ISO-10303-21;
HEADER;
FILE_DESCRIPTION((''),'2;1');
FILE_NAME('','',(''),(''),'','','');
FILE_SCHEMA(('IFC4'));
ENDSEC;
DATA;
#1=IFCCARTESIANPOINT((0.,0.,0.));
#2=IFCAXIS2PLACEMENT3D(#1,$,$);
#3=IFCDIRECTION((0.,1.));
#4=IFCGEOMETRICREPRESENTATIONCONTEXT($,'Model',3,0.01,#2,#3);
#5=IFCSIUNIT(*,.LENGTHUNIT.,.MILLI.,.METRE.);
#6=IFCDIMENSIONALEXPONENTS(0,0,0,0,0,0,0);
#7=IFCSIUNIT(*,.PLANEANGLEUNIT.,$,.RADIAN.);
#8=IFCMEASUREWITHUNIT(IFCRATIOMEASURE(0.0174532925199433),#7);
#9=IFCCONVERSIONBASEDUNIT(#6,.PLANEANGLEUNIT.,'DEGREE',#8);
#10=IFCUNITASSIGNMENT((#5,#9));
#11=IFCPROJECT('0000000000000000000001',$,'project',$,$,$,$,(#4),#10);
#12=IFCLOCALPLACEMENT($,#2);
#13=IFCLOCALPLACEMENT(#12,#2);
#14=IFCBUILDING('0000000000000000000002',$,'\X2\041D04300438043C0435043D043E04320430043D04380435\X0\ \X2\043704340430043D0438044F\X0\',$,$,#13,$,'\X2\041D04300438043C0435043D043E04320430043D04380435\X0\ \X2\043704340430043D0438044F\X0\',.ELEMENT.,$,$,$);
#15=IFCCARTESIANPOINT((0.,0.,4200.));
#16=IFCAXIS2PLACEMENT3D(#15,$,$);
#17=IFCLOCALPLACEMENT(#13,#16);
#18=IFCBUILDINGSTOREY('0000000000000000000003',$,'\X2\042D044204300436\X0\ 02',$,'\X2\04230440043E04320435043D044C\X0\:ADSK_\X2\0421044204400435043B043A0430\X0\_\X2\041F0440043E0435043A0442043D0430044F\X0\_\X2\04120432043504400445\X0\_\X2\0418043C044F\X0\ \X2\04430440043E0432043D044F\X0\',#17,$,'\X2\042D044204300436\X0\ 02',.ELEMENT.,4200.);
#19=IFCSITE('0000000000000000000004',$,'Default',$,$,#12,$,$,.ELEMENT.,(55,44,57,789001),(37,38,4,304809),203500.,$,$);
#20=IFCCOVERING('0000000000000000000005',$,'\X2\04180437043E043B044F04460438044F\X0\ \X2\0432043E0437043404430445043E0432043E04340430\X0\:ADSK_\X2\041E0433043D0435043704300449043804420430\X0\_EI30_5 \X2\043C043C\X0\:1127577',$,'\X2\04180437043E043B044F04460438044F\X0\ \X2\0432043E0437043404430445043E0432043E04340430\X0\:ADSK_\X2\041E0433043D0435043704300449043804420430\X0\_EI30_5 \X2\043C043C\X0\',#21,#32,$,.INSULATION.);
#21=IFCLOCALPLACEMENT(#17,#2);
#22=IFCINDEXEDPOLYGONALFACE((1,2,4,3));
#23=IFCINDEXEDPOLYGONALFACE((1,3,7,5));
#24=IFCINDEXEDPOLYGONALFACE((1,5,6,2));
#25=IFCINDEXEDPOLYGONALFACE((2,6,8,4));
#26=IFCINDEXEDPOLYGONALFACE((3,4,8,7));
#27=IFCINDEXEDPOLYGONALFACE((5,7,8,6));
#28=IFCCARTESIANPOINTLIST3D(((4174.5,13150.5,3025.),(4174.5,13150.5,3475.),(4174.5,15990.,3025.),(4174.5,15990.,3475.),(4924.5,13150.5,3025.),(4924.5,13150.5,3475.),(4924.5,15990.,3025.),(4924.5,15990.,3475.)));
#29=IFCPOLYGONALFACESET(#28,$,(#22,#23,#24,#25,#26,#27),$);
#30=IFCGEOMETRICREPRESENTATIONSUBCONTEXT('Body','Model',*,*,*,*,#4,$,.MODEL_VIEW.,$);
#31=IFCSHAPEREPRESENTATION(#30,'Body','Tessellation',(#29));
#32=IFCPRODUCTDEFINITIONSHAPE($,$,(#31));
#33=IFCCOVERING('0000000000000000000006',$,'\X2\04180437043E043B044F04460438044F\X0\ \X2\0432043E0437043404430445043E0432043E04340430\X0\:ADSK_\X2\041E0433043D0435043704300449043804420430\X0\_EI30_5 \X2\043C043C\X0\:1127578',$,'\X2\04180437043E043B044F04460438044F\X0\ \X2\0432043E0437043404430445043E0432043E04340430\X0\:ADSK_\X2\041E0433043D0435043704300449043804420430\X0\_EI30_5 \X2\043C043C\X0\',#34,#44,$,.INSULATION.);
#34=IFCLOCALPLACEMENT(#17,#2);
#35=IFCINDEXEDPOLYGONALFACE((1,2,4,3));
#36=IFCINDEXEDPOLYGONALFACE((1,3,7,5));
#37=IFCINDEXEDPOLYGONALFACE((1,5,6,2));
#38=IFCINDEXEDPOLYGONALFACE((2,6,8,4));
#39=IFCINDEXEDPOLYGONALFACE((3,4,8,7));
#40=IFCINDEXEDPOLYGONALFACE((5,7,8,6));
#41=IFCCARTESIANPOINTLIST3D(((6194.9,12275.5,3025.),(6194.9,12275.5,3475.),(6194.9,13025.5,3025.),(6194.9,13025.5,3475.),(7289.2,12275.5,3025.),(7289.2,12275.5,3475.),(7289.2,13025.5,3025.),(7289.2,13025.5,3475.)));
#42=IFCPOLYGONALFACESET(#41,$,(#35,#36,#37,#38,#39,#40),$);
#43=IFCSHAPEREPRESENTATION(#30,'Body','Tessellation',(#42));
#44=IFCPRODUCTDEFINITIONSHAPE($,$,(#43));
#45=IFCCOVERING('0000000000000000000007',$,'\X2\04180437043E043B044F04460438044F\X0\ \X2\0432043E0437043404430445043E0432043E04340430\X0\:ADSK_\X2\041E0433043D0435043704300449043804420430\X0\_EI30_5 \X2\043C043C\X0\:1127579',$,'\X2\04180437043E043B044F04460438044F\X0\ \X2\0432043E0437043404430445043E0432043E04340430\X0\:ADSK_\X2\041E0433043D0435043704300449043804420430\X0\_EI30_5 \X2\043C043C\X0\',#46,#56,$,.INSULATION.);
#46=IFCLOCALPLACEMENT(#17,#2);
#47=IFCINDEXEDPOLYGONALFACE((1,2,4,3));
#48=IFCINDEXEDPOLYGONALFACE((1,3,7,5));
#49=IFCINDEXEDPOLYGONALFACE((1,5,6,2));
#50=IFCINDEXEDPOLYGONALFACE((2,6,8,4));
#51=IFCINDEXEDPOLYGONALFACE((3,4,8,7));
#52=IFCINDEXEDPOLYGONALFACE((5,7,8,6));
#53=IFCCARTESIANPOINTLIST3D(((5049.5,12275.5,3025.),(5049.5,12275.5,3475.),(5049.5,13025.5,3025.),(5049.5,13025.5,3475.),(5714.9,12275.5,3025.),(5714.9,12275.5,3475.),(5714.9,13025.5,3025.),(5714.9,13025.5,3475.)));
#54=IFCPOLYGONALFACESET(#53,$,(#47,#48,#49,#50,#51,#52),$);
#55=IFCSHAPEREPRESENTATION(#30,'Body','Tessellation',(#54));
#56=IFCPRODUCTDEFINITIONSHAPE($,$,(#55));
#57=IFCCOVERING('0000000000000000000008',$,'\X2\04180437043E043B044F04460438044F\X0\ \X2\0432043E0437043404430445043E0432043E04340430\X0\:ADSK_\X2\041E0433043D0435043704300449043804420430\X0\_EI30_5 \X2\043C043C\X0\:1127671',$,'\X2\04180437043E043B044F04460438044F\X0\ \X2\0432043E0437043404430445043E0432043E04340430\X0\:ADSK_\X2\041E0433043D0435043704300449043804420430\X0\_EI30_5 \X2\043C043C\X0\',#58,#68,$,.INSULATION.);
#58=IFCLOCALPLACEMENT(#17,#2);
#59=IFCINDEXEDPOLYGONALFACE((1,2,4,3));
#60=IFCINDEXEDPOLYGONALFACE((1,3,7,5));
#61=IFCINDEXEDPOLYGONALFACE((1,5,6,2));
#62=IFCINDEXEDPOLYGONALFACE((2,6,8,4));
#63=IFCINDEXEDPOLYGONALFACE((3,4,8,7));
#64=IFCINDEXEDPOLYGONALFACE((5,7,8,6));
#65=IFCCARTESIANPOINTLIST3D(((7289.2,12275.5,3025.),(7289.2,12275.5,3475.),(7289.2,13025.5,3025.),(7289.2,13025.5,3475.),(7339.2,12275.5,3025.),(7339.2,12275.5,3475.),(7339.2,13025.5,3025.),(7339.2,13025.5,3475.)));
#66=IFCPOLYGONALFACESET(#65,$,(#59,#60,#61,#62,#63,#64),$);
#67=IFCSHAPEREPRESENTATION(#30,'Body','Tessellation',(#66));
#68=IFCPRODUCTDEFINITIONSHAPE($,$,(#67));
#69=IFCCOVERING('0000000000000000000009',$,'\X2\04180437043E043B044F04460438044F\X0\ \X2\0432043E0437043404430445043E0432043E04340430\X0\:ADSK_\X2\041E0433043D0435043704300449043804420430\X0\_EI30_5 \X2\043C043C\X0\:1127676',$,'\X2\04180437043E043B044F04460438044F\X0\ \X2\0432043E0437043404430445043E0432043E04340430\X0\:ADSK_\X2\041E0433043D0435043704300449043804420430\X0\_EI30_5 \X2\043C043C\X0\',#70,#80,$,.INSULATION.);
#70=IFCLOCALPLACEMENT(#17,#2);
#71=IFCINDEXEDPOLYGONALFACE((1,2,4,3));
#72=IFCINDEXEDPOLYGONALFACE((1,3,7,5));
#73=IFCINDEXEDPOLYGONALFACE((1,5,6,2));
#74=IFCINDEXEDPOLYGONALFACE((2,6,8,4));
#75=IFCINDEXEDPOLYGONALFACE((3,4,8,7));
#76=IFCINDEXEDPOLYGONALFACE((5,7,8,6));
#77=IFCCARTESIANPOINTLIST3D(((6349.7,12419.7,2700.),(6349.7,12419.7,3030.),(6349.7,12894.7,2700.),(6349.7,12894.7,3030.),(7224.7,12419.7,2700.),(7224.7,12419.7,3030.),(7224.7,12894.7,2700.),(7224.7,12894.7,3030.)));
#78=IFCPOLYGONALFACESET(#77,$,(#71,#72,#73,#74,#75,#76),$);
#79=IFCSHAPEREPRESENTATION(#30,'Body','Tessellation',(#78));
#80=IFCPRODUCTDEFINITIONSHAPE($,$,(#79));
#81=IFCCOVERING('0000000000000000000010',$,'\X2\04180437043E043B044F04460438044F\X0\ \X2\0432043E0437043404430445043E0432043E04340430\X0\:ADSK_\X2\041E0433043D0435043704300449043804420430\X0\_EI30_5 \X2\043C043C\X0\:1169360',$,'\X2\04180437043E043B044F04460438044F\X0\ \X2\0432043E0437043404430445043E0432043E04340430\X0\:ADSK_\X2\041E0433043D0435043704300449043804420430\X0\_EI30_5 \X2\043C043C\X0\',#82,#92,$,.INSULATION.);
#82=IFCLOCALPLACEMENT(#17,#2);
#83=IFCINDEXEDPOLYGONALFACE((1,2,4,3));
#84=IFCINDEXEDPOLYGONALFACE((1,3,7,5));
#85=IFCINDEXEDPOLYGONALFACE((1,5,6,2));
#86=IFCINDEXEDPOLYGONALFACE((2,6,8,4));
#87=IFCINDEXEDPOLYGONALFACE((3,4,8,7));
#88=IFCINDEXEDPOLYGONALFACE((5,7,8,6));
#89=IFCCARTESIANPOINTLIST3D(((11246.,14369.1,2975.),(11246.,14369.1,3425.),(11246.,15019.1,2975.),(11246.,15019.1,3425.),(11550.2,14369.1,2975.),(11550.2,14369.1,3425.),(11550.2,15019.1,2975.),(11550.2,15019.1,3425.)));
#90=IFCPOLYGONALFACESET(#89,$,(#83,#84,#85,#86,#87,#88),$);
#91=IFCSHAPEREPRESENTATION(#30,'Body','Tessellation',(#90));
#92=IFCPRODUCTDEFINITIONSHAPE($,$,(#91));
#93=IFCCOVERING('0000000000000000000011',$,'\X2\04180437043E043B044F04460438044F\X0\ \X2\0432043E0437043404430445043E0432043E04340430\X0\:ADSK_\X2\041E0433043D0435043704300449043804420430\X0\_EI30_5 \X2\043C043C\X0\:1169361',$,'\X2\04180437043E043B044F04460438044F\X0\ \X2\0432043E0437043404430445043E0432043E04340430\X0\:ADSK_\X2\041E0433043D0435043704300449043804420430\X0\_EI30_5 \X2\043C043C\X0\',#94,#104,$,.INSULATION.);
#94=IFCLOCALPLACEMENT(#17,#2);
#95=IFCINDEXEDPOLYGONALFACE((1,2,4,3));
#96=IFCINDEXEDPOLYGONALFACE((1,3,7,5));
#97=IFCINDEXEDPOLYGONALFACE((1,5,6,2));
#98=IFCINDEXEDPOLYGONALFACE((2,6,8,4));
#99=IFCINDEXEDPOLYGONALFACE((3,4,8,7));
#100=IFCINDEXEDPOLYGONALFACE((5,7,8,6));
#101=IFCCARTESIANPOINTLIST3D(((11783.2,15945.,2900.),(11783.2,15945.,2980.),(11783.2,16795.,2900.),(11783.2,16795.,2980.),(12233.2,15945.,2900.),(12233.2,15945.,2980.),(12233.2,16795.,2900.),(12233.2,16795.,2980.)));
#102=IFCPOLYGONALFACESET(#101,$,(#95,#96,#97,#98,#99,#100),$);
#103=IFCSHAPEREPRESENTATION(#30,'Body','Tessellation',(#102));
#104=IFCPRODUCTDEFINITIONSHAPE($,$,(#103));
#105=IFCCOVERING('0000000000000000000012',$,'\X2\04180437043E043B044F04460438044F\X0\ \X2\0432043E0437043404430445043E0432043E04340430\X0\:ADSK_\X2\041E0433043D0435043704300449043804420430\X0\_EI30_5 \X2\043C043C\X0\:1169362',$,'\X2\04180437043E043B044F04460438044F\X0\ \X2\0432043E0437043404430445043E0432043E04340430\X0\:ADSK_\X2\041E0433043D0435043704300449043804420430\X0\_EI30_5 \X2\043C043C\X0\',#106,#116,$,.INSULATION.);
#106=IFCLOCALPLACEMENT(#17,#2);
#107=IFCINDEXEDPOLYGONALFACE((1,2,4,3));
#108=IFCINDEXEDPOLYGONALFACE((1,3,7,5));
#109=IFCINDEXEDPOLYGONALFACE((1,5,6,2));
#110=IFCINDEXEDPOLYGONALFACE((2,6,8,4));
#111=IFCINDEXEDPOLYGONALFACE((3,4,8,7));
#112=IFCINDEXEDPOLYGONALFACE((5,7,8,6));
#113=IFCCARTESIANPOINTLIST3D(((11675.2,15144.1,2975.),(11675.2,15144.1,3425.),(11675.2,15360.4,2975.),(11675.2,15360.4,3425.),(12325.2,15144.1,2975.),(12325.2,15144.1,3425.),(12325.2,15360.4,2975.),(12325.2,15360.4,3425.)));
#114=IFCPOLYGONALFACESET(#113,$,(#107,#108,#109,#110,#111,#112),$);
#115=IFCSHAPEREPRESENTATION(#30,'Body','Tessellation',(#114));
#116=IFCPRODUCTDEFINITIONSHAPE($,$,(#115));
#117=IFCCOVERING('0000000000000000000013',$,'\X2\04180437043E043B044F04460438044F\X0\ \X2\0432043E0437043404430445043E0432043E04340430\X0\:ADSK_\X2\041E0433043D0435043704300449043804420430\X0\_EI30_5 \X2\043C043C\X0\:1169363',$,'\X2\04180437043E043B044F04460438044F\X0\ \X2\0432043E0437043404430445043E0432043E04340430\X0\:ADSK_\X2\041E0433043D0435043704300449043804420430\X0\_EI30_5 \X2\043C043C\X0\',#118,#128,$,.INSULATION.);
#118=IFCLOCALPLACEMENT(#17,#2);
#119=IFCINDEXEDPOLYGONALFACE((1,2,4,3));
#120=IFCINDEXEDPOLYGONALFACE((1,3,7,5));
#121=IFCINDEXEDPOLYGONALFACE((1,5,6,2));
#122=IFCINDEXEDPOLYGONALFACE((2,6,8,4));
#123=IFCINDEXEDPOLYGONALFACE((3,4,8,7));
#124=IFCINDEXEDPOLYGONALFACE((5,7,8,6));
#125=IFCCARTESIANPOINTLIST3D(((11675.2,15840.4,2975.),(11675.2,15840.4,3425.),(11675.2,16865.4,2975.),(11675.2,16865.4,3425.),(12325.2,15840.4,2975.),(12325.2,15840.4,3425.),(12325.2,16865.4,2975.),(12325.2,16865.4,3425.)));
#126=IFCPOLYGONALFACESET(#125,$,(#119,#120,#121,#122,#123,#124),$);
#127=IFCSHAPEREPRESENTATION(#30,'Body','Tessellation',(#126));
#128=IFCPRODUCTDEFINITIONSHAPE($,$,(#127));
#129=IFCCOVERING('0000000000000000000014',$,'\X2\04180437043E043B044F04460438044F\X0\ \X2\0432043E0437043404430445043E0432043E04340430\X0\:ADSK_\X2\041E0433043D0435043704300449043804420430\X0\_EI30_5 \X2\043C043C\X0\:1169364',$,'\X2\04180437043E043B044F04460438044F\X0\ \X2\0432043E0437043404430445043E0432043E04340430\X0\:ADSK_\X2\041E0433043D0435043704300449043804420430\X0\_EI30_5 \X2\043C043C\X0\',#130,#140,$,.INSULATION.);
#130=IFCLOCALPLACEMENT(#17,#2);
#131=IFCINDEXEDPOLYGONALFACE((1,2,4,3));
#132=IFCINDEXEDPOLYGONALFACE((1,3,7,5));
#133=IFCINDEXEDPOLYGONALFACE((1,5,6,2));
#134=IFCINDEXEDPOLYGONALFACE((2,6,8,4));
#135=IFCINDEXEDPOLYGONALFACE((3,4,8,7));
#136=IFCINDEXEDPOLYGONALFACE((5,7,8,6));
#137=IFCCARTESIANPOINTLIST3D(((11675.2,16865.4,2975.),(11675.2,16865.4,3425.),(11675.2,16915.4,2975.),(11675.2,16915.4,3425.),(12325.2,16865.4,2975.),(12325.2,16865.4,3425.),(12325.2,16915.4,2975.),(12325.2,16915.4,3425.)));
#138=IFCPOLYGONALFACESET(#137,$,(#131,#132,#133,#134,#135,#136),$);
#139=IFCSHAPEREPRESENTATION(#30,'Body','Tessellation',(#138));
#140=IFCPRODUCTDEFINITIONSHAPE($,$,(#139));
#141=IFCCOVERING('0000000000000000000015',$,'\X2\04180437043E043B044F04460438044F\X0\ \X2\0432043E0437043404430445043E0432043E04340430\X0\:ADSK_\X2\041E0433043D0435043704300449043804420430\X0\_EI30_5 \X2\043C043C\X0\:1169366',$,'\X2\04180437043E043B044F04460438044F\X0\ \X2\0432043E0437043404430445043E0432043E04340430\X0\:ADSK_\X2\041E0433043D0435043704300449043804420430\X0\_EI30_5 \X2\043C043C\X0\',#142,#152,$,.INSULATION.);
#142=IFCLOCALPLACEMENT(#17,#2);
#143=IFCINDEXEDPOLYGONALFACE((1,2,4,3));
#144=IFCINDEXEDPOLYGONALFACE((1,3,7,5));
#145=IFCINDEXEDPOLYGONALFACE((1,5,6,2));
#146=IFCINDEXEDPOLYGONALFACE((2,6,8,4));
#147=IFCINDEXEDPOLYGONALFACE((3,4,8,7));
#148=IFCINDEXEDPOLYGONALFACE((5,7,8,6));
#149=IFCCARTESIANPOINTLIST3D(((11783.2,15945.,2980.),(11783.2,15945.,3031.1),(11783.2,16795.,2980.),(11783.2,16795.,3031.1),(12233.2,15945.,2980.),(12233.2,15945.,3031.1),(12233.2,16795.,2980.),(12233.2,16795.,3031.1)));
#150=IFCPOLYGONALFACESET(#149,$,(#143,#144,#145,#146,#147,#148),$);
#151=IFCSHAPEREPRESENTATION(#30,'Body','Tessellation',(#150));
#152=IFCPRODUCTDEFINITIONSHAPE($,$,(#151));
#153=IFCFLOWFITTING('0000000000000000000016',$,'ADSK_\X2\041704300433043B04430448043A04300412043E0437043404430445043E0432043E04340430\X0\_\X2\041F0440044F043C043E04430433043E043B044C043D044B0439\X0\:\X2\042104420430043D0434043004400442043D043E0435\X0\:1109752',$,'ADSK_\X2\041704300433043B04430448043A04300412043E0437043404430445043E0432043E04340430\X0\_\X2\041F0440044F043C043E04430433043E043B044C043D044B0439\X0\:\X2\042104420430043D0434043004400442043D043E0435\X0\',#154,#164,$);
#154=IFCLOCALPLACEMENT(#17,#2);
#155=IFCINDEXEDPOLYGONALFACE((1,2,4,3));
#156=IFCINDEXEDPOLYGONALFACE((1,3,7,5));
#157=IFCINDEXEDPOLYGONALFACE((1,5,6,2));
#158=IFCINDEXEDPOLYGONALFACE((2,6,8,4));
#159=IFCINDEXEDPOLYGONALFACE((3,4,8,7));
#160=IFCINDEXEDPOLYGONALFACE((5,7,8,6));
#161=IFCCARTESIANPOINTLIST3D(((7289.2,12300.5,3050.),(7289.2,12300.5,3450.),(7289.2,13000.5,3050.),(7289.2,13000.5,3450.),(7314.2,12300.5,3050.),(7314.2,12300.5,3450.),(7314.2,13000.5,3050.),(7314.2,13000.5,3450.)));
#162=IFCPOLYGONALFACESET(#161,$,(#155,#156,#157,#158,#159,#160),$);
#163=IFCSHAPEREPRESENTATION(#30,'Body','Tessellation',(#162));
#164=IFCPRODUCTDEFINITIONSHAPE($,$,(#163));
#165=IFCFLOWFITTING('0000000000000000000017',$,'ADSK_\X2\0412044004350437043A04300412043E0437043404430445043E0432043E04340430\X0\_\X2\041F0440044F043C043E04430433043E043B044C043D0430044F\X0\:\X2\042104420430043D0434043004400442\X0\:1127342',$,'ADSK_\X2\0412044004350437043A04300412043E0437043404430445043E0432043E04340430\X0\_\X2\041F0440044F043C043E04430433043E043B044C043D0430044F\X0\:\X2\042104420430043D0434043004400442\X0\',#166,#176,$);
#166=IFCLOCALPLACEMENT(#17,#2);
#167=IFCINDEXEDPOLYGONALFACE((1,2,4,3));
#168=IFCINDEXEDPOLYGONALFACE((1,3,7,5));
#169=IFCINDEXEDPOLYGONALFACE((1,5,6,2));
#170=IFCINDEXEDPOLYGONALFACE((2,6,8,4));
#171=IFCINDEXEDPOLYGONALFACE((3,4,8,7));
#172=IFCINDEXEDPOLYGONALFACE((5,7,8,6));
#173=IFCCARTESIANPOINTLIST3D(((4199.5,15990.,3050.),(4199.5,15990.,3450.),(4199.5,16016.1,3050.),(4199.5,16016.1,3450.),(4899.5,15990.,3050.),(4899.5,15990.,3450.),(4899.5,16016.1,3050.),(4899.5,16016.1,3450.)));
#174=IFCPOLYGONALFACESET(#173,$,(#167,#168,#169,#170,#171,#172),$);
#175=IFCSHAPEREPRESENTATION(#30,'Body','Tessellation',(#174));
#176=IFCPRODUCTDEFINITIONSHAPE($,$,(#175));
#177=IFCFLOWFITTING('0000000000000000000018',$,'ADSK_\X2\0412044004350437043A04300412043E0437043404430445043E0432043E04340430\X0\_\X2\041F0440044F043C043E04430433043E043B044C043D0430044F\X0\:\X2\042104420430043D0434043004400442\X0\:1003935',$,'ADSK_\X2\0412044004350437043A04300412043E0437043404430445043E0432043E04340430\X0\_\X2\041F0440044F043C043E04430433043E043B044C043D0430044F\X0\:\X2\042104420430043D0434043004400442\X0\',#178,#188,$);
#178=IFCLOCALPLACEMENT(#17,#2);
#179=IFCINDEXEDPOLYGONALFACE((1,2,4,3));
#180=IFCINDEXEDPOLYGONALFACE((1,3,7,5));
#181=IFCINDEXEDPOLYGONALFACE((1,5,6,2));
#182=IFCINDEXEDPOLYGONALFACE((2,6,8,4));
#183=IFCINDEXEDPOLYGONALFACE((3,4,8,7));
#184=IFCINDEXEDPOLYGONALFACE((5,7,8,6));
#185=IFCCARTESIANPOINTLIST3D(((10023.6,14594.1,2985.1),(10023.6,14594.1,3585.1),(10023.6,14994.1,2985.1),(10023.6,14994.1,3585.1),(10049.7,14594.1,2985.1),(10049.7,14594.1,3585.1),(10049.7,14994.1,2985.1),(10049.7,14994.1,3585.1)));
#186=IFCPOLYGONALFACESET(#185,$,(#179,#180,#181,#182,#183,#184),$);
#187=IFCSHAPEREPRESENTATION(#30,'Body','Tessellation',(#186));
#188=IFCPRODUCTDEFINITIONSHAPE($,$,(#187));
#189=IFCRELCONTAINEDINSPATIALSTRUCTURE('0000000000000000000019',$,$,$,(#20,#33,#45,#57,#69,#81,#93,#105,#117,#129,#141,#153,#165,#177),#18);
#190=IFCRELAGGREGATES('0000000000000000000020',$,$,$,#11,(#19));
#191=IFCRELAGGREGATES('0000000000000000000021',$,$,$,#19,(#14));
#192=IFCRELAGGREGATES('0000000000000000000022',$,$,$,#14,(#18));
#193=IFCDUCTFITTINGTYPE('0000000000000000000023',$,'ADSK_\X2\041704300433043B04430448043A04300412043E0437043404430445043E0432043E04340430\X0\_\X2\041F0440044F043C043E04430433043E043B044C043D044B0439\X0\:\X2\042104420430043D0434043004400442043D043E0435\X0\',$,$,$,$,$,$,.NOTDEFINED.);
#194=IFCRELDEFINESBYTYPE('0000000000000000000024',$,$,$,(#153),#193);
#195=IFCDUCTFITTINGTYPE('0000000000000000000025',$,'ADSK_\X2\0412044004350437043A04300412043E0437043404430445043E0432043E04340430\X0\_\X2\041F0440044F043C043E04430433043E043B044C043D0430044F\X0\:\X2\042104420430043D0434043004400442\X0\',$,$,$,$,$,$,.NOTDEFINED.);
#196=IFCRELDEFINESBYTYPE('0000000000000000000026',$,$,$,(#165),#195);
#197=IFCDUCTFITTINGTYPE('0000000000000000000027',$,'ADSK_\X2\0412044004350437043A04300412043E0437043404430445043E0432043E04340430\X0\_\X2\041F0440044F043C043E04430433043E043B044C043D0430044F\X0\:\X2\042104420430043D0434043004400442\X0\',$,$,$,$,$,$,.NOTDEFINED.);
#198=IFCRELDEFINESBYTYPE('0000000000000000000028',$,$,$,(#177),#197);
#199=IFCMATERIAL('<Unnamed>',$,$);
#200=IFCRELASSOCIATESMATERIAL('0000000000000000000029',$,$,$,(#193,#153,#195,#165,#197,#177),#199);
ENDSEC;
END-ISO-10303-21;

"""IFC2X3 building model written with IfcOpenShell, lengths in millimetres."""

from ifc_helpers import new_model, entity, si_unit, converted_unit, direction, frame, frame_2d, origin, origin_2d_with_axis, place, context, subcontext, project, spatial, rectangle, extrude, source, transform, mapped, material, type_object, type_shapes, element, save


model = new_model("IFC2X3")

# Units and contexts
model_context = context("Model", 3, precision=0.01, world=origin(), true_north=direction((0.0, 1.0)))
body_context = subcontext(model_context, "Body", "Model", "MODEL_VIEW")
ifc_project = project(units=[si_unit("LENGTHUNIT", "METRE", prefix="MILLI"), converted_unit("PLANEANGLEUNIT", "DEGREE", entity("IfcRatioMeasure", 0.0174532925199433), si_unit("PLANEANGLEUNIT", "RADIAN"), dimensions=[0, 0, 0, 0, 0, 0, 0])], contexts=[model_context])

# Site, building, storey
site_placement = place(None, frame((0.0, 0.0, 0.0)))
site = spatial("IfcSite", under=ifc_project, at=site_placement, Name="Default", CompositionType="ELEMENT", RefLatitude=(55, 44, 57, 789001), RefLongitude=(37, 38, 4, 304809), RefElevation=203500.0)
building_placement = place(site_placement, origin())
building = spatial("IfcBuilding", under=site, at=building_placement, Name="Наименование здания", LongName="Наименование здания", CompositionType="ELEMENT")
storey_placement = place(building_placement, frame((0.0, 0.0, 4200.0)))
storey = spatial("IfcBuildingStorey", under=building, at=storey_placement, Name="Этаж 02", ObjectType="Уровень:ADSK_Стрелка_Проектная_Вверх_Имя уровня", LongName="Этаж 02", CompositionType="ELEMENT", Elevation=4200.0)

# Coverings
covering_1_placement = place(storey_placement, frame((4174.5, 13150.5, 3025.0)))
element("IfcCovering", 1, at=covering_1_placement, inside=storey, Name="Изоляция воздуховода:ADSK_Огнезащита_EI30_5 мм:1127577", ObjectType="Изоляция воздуховода:ADSK_Огнезащита_EI30_5 мм", PredefinedType="INSULATION", context=body_context, shape_type="SweptSolid", body=[
    extrude(rectangle(XDim=2839.5, YDim=750.0, at=frame_2d((0.0, 0.0), x_axis=(1.0, 0.0))), frame((375.0, 1419.8, 0.0), z_axis=(0.0, 0.0, 1.0), x_axis=(0.0, 1.0, 0.0)), (0.0, 0.0, 1.0), 450.0),
])
covering_2_placement = place(storey_placement, frame((6194.9, 12275.5, 3025.0)))
element("IfcCovering", 2, at=covering_2_placement, inside=storey, Name="Изоляция воздуховода:ADSK_Огнезащита_EI30_5 мм:1127578", ObjectType="Изоляция воздуховода:ADSK_Огнезащита_EI30_5 мм", PredefinedType="INSULATION", context=body_context, shape_type="SweptSolid", body=[
    extrude(rectangle(XDim=1094.2, YDim=750.0, at=origin_2d_with_axis()), frame((547.1, 375.0, 0.0), z_axis=(0.0, 0.0, 1.0), x_axis=(-1.0, 0.0, 0.0)), (0.0, 0.0, 1.0), 450.0),
])
covering_3_placement = place(storey_placement, frame((5049.5, 12275.5, 3025.0)))
element("IfcCovering", 3, at=covering_3_placement, inside=storey, Name="Изоляция воздуховода:ADSK_Огнезащита_EI30_5 мм:1127579", ObjectType="Изоляция воздуховода:ADSK_Огнезащита_EI30_5 мм", PredefinedType="INSULATION", context=body_context, shape_type="SweptSolid", body=[
    extrude(rectangle(XDim=665.5, YDim=750.0, at=origin_2d_with_axis()), frame((332.7, 375.0, 0.0), z_axis=(0.0, 0.0, 1.0), x_axis=(-1.0, 0.0, 0.0)), (0.0, 0.0, 1.0), 450.0),
])
covering_4_placement = place(storey_placement, frame((7289.2, 12275.5, 3025.0)))
element("IfcCovering", 4, at=covering_4_placement, inside=storey, Name="Изоляция воздуховода:ADSK_Огнезащита_EI30_5 мм:1127671", ObjectType="Изоляция воздуховода:ADSK_Огнезащита_EI30_5 мм", PredefinedType="INSULATION", context=body_context, shape_type="SweptSolid", body=[
    extrude(rectangle(XDim=50.0, YDim=750.0, at=frame_2d((0.0, 0.0), x_axis=(1.0, 0.0))), frame((25.0, 375.0, 0.0), z_axis=(0.0, 0.0, 1.0), x_axis=(-1.0, 0.0, 0.0)), (0.0, 0.0, 1.0), 450.0),
])
covering_5_placement = place(storey_placement, frame((6349.7, 12419.7, 2700.0)))
element("IfcCovering", 5, at=covering_5_placement, inside=storey, Name="Изоляция воздуховода:ADSK_Огнезащита_EI30_5 мм:1127676", ObjectType="Изоляция воздуховода:ADSK_Огнезащита_EI30_5 мм", PredefinedType="INSULATION", context=body_context, shape_type="SweptSolid", body=[
    extrude(rectangle(XDim=875.0, YDim=475.0, at=origin_2d_with_axis()), frame((437.5, 237.5, 0.0)), (0.0, 0.0, 1.0), 330.0),
])
covering_6_placement = place(storey_placement, frame((11246.0, 14369.1, 2975.0)))
element("IfcCovering", 6, at=covering_6_placement, inside=storey, Name="Изоляция воздуховода:ADSK_Огнезащита_EI30_5 мм:1169360", ObjectType="Изоляция воздуховода:ADSK_Огнезащита_EI30_5 мм", PredefinedType="INSULATION", context=body_context, shape_type="SweptSolid", body=[
    extrude(rectangle(XDim=304.2, YDim=650.0, at=frame_2d((0.0, 0.0), x_axis=(1.0, 0.0))), frame((152.1, 325.0, 0.0), z_axis=(0.0, 0.0, 1.0), x_axis=(-1.0, 0.0, 0.0)), (0.0, 0.0, 1.0), 450.0),
])
covering_7_placement = place(storey_placement, frame((11783.2, 15945.0, 2900.0)))
element("IfcCovering", 7, at=covering_7_placement, inside=storey, Name="Изоляция воздуховода:ADSK_Огнезащита_EI30_5 мм:1169361", ObjectType="Изоляция воздуховода:ADSK_Огнезащита_EI30_5 мм", PredefinedType="INSULATION", context=body_context, shape_type="SweptSolid", body=[
    extrude(rectangle(XDim=850.0, YDim=450.0, at=origin_2d_with_axis()), frame((225.0, 425.0, 0.0), z_axis=(0.0, 0.0, 1.0), x_axis=(0.0, -1.0, 0.0)), (0.0, 0.0, 1.0), 80.0),
])
covering_8_placement = place(storey_placement, frame((11675.2, 15144.1, 2975.0)))
element("IfcCovering", 8, at=covering_8_placement, inside=storey, Name="Изоляция воздуховода:ADSK_Огнезащита_EI30_5 мм:1169362", ObjectType="Изоляция воздуховода:ADSK_Огнезащита_EI30_5 мм", PredefinedType="INSULATION", context=body_context, shape_type="SweptSolid", body=[
    extrude(rectangle(XDim=216.3, YDim=650.0, at=origin_2d_with_axis()), frame((325.0, 108.1, 0.0), z_axis=(0.0, 0.0, 1.0), x_axis=(0.0, -1.0, 0.0)), (0.0, 0.0, 1.0), 450.0),
])
covering_9_placement = place(storey_placement, frame((11675.2, 15840.4, 2975.0)))
element("IfcCovering", 9, at=covering_9_placement, inside=storey, Name="Изоляция воздуховода:ADSK_Огнезащита_EI30_5 мм:1169363", ObjectType="Изоляция воздуховода:ADSK_Огнезащита_EI30_5 мм", PredefinedType="INSULATION", context=body_context, shape_type="SweptSolid", body=[
    extrude(rectangle(XDim=1025.0, YDim=650.0, at=origin_2d_with_axis()), frame((325.0, 512.5, 0.0), z_axis=(0.0, 0.0, 1.0), x_axis=(0.0, 1.0, 0.0)), (0.0, 0.0, 1.0), 450.0),
])
covering_10_placement = place(storey_placement, frame((11675.2, 16865.4, 2975.0)))
element("IfcCovering", 10, at=covering_10_placement, inside=storey, Name="Изоляция воздуховода:ADSK_Огнезащита_EI30_5 мм:1169364", ObjectType="Изоляция воздуховода:ADSK_Огнезащита_EI30_5 мм", PredefinedType="INSULATION", context=body_context, shape_type="SweptSolid", body=[
    extrude(rectangle(XDim=50.0, YDim=650.0, at=origin_2d_with_axis()), frame((325.0, 25.0, 0.0), z_axis=(0.0, 0.0, 1.0), x_axis=(0.0, -1.0, 0.0)), (0.0, 0.0, 1.0), 450.0),
])
covering_11_placement = place(storey_placement, frame((11783.2, 15945.0, 2980.0)))
element("IfcCovering", 11, at=covering_11_placement, inside=storey, Name="Изоляция воздуховода:ADSK_Огнезащита_EI30_5 мм:1169366", ObjectType="Изоляция воздуховода:ADSK_Огнезащита_EI30_5 мм", PredefinedType="INSULATION", context=body_context, shape_type="SweptSolid", body=[
    extrude(rectangle(XDim=850.0, YDim=450.0, at=frame_2d((0.0, 0.0), x_axis=(1.0, 0.0))), frame((225.0, 425.0, 0.0), z_axis=(0.0, 0.0, 1.0), x_axis=(0.0, -1.0, 0.0)), (0.0, 0.0, 1.0), 51.1),
])

# Flow fittings
ifc_material_1 = material(Name="<Unnamed>")
duct_fitting_type_1 = type_object("IfcDuctFittingType", Name="ADSK_ЗаглушкаВоздуховода_Прямоугольный:Стандартное", PredefinedType="NOTDEFINED", material=ifc_material_1)
shared_shape_1 = source(origin(), body_context, "Body", "SweptSolid", [
    extrude(rectangle(XDim=25.0, YDim=700.0, at=frame_2d((0.0, 0.0), x_axis=(1.0, 0.0))), frame((12.5, 0.0, -200.0)), (0.0, 0.0, 1.0), 400.0),
])
type_shapes(duct_fitting_type_1, [shared_shape_1])
flow_fitting_1_placement = place(storey_placement, frame((7289.2, 12650.5, 3250.0)))
element("IfcFlowFitting", 12, at=flow_fitting_1_placement, inside=storey, type_object=duct_fitting_type_1, material=ifc_material_1, Name="ADSK_ЗаглушкаВоздуховода_Прямоугольный:Стандартное:1109752", ObjectType="ADSK_ЗаглушкаВоздуховода_Прямоугольный:Стандартное", context=body_context, shape_type="MappedRepresentation", body=[
    mapped(shared_shape_1, transform((0.0, 0.0, 0.0), scale=1.0)),
])
duct_fitting_type_2 = type_object("IfcDuctFittingType", Name="ADSK_ВрезкаВоздуховода_Прямоугольная:Стандарт", PredefinedType="NOTDEFINED", material=ifc_material_1)
shared_shape_2 = source(origin(), body_context, "Body", "SweptSolid", [
    extrude(rectangle(XDim=26.1, YDim=400.0, at=frame_2d((0.0, 0.0), x_axis=(1.0, 0.0))), frame((7.0, 0.0, -350.0)), (0.0, 0.0, 1.0), 700.0),
])
type_shapes(duct_fitting_type_2, [shared_shape_2])
flow_fitting_2_placement = place(storey_placement, frame((4549.5, 16010.0, 3250.0), z_axis=(-1.0, 0.0, 0.0), x_axis=(0.0, -1.0, 0.0)))
element("IfcFlowFitting", 13, at=flow_fitting_2_placement, inside=storey, type_object=duct_fitting_type_2, material=ifc_material_1, Name="ADSK_ВрезкаВоздуховода_Прямоугольная:Стандарт:1127342", ObjectType="ADSK_ВрезкаВоздуховода_Прямоугольная:Стандарт", context=body_context, shape_type="MappedRepresentation", body=[
    mapped(shared_shape_2, transform((0.0, 0.0, 0.0), scale=1.0)),
])
duct_fitting_type_3 = type_object("IfcDuctFittingType", Name="ADSK_ВрезкаВоздуховода_Прямоугольная:Стандарт", PredefinedType="NOTDEFINED", material=ifc_material_1)
shared_shape_3 = source(origin(), body_context, "Body", "SweptSolid", [
    extrude(rectangle(XDim=26.1, YDim=600.0, at=frame_2d((0.0, 0.0), x_axis=(1.0, 0.0))), frame((7.0, 0.0, -200.0)), (0.0, 0.0, 1.0), 400.0),
])
type_shapes(duct_fitting_type_3, [shared_shape_3])
flow_fitting_3_placement = place(storey_placement, frame((10029.7, 14794.1, 3285.1), z_axis=(0.0, -1.0, 0.0), x_axis=(1.0, 0.0, 0.0)))
element("IfcFlowFitting", 14, at=flow_fitting_3_placement, inside=storey, type_object=duct_fitting_type_3, material=ifc_material_1, Name="ADSK_ВрезкаВоздуховода_Прямоугольная:Стандарт:1003935", ObjectType="ADSK_ВрезкаВоздуховода_Прямоугольная:Стандарт", context=body_context, shape_type="MappedRepresentation", body=[
    mapped(shared_shape_3, transform((0.0, 0.0, 0.0), scale=1.0)),
])

save(model, "model.ifc")
